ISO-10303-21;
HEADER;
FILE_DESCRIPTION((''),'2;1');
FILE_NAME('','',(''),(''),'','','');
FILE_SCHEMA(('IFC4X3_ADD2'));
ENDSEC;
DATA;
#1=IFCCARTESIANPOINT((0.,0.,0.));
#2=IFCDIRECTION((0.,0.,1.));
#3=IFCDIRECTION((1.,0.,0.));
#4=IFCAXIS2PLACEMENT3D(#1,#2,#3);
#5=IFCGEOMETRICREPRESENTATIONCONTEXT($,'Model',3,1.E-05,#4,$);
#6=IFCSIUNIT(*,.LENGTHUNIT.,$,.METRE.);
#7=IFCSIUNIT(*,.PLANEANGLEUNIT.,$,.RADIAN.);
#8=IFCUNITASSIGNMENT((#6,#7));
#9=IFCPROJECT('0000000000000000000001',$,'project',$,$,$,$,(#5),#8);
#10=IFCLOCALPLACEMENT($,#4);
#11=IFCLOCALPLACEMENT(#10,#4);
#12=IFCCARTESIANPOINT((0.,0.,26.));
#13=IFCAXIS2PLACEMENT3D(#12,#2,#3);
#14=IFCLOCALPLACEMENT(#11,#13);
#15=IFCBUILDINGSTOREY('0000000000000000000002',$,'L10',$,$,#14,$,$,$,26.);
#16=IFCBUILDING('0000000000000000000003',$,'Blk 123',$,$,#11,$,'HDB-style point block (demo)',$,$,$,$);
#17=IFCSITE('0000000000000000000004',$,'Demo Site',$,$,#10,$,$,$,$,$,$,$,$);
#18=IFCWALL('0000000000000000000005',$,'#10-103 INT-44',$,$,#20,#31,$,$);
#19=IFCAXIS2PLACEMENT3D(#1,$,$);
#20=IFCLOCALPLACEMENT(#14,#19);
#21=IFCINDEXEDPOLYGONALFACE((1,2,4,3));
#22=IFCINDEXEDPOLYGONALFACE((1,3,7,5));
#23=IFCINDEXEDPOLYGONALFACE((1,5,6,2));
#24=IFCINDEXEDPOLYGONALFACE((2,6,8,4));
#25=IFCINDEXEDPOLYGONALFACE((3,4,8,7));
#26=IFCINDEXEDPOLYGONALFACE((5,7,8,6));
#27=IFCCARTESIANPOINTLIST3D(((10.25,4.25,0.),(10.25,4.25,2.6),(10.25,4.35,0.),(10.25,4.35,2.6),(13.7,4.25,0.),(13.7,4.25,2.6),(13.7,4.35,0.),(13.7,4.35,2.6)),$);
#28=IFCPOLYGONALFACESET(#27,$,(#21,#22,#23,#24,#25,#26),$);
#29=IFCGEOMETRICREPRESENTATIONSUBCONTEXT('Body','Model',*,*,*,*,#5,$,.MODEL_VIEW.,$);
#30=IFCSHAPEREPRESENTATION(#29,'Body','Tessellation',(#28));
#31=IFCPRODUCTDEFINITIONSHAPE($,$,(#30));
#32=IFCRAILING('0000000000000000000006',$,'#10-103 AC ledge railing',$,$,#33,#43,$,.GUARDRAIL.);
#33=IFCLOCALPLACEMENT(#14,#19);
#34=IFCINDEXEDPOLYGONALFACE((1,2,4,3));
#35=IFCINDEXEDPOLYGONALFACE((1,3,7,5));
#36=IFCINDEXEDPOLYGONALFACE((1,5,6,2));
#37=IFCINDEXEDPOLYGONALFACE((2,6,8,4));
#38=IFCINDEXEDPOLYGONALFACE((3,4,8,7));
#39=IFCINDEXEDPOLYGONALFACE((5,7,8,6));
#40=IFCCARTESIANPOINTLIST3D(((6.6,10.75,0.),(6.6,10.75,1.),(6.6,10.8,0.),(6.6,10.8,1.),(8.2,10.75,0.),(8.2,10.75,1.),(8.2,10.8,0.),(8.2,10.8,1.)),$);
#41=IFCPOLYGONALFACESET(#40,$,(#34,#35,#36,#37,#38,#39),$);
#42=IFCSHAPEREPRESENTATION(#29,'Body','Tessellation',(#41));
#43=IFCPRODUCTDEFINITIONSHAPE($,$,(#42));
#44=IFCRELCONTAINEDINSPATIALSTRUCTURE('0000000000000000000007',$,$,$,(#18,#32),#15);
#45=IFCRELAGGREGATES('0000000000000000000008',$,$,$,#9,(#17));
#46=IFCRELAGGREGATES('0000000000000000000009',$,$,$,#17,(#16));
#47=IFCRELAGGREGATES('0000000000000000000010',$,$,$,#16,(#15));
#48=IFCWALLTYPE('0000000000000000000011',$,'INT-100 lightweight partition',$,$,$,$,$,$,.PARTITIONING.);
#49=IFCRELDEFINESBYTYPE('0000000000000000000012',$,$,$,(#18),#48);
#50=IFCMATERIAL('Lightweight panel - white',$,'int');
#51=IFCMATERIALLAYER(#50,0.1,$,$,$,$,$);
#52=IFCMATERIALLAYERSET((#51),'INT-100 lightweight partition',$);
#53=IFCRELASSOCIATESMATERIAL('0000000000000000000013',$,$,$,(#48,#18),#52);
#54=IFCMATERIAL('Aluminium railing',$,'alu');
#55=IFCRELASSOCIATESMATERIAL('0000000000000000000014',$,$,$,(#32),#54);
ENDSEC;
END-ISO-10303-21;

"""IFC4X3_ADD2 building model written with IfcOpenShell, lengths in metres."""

from ifc_helpers import new_model, si_unit, frame, origin, origin_with_axes, place, context, subcontext, project, spatial, polyline, indexed_curve, outline, extrude, material, layer, layer_set, layer_usage, type_object, element, save


model = new_model("IFC4X3_ADD2")

# Units and contexts
model_context = context("Model", 3, precision=1e-05, world=origin_with_axes())
body_context = subcontext(model_context, "Body", "Model", "MODEL_VIEW")
ifc_project = project(units=[si_unit("LENGTHUNIT", "METRE"), si_unit("PLANEANGLEUNIT", "RADIAN")], contexts=[model_context])

# Site, building, storey
site_placement = place(None, origin_with_axes())
site = spatial("IfcSite", under=ifc_project, at=site_placement, Name="Demo Site")
building_placement = place(site_placement, origin_with_axes())
building = spatial("IfcBuilding", under=site, at=building_placement, Name="Blk 123", LongName="HDB-style point block (demo)")
storey_placement = place(building_placement, frame((0.0, 0.0, 26.0), z_axis=(0.0, 0.0, 1.0), x_axis=(1.0, 0.0, 0.0)))
storey = spatial("IfcBuildingStorey", under=building, at=storey_placement, Name="L10", Elevation=26.0)

# Wall
ifc_material_1 = material(Name="Lightweight panel - white", Category="int")
ifc_layer_1 = layer(ifc_material_1, 0.1)
ifc_layer_set_1 = layer_set([ifc_layer_1], Name="INT-100 lightweight partition")
ifc_layer_usage_1 = layer_usage(ifc_layer_set_1, "AXIS2", "POSITIVE", -0.05)
wall_type_1 = type_object("IfcWallType", Name="INT-100 lightweight partition", PredefinedType="PARTITIONING", material=ifc_layer_set_1)
wall_1_placement = place(storey_placement, frame((10.25, 4.3, 0.0), z_axis=(0.0, 0.0, 1.0), x_axis=(1.0, 0.0, 0.0)))
element("IfcWall", 1, at=wall_1_placement, inside=storey, type_object=wall_type_1, material=ifc_layer_usage_1, Name="#10-103 INT-44", context=body_context, shape_type="SweptSolid", body=[
    extrude(outline(indexed_curve([(0.0, 0.0), (0.0, 0.1), (3.45, 0.1), (3.45, 0.0), (0.0, 0.0)], self_intersect=False)), frame((0.0, -0.05, 0.0), z_axis=(0.0, 0.0, 1.0), x_axis=(1.0, 0.0, 0.0)), (0.0, 0.0, 1.0), 2.6),
])

# Railing
ifc_material_2 = material(Name="Aluminium railing", Category="alu")
railing_placement = place(storey_placement, frame((7.4, 10.775, 0.0), z_axis=(0.0, 0.0, 1.0), x_axis=(1.0, 0.0, 0.0)))
element("IfcRailing", 2, at=railing_placement, inside=storey, material=ifc_material_2, Name="#10-103 AC ledge railing", PredefinedType="GUARDRAIL", context=body_context, shape_type="SweptSolid", body=[
    extrude(outline(polyline([(0.8, -0.025), (0.8, 0.025), (-0.8, 0.025), (-0.8, -0.025), (0.8, -0.025)])), origin(), (0.0, 0.0, 1.0), 1.0),
])

save(model, "model.ifc")
